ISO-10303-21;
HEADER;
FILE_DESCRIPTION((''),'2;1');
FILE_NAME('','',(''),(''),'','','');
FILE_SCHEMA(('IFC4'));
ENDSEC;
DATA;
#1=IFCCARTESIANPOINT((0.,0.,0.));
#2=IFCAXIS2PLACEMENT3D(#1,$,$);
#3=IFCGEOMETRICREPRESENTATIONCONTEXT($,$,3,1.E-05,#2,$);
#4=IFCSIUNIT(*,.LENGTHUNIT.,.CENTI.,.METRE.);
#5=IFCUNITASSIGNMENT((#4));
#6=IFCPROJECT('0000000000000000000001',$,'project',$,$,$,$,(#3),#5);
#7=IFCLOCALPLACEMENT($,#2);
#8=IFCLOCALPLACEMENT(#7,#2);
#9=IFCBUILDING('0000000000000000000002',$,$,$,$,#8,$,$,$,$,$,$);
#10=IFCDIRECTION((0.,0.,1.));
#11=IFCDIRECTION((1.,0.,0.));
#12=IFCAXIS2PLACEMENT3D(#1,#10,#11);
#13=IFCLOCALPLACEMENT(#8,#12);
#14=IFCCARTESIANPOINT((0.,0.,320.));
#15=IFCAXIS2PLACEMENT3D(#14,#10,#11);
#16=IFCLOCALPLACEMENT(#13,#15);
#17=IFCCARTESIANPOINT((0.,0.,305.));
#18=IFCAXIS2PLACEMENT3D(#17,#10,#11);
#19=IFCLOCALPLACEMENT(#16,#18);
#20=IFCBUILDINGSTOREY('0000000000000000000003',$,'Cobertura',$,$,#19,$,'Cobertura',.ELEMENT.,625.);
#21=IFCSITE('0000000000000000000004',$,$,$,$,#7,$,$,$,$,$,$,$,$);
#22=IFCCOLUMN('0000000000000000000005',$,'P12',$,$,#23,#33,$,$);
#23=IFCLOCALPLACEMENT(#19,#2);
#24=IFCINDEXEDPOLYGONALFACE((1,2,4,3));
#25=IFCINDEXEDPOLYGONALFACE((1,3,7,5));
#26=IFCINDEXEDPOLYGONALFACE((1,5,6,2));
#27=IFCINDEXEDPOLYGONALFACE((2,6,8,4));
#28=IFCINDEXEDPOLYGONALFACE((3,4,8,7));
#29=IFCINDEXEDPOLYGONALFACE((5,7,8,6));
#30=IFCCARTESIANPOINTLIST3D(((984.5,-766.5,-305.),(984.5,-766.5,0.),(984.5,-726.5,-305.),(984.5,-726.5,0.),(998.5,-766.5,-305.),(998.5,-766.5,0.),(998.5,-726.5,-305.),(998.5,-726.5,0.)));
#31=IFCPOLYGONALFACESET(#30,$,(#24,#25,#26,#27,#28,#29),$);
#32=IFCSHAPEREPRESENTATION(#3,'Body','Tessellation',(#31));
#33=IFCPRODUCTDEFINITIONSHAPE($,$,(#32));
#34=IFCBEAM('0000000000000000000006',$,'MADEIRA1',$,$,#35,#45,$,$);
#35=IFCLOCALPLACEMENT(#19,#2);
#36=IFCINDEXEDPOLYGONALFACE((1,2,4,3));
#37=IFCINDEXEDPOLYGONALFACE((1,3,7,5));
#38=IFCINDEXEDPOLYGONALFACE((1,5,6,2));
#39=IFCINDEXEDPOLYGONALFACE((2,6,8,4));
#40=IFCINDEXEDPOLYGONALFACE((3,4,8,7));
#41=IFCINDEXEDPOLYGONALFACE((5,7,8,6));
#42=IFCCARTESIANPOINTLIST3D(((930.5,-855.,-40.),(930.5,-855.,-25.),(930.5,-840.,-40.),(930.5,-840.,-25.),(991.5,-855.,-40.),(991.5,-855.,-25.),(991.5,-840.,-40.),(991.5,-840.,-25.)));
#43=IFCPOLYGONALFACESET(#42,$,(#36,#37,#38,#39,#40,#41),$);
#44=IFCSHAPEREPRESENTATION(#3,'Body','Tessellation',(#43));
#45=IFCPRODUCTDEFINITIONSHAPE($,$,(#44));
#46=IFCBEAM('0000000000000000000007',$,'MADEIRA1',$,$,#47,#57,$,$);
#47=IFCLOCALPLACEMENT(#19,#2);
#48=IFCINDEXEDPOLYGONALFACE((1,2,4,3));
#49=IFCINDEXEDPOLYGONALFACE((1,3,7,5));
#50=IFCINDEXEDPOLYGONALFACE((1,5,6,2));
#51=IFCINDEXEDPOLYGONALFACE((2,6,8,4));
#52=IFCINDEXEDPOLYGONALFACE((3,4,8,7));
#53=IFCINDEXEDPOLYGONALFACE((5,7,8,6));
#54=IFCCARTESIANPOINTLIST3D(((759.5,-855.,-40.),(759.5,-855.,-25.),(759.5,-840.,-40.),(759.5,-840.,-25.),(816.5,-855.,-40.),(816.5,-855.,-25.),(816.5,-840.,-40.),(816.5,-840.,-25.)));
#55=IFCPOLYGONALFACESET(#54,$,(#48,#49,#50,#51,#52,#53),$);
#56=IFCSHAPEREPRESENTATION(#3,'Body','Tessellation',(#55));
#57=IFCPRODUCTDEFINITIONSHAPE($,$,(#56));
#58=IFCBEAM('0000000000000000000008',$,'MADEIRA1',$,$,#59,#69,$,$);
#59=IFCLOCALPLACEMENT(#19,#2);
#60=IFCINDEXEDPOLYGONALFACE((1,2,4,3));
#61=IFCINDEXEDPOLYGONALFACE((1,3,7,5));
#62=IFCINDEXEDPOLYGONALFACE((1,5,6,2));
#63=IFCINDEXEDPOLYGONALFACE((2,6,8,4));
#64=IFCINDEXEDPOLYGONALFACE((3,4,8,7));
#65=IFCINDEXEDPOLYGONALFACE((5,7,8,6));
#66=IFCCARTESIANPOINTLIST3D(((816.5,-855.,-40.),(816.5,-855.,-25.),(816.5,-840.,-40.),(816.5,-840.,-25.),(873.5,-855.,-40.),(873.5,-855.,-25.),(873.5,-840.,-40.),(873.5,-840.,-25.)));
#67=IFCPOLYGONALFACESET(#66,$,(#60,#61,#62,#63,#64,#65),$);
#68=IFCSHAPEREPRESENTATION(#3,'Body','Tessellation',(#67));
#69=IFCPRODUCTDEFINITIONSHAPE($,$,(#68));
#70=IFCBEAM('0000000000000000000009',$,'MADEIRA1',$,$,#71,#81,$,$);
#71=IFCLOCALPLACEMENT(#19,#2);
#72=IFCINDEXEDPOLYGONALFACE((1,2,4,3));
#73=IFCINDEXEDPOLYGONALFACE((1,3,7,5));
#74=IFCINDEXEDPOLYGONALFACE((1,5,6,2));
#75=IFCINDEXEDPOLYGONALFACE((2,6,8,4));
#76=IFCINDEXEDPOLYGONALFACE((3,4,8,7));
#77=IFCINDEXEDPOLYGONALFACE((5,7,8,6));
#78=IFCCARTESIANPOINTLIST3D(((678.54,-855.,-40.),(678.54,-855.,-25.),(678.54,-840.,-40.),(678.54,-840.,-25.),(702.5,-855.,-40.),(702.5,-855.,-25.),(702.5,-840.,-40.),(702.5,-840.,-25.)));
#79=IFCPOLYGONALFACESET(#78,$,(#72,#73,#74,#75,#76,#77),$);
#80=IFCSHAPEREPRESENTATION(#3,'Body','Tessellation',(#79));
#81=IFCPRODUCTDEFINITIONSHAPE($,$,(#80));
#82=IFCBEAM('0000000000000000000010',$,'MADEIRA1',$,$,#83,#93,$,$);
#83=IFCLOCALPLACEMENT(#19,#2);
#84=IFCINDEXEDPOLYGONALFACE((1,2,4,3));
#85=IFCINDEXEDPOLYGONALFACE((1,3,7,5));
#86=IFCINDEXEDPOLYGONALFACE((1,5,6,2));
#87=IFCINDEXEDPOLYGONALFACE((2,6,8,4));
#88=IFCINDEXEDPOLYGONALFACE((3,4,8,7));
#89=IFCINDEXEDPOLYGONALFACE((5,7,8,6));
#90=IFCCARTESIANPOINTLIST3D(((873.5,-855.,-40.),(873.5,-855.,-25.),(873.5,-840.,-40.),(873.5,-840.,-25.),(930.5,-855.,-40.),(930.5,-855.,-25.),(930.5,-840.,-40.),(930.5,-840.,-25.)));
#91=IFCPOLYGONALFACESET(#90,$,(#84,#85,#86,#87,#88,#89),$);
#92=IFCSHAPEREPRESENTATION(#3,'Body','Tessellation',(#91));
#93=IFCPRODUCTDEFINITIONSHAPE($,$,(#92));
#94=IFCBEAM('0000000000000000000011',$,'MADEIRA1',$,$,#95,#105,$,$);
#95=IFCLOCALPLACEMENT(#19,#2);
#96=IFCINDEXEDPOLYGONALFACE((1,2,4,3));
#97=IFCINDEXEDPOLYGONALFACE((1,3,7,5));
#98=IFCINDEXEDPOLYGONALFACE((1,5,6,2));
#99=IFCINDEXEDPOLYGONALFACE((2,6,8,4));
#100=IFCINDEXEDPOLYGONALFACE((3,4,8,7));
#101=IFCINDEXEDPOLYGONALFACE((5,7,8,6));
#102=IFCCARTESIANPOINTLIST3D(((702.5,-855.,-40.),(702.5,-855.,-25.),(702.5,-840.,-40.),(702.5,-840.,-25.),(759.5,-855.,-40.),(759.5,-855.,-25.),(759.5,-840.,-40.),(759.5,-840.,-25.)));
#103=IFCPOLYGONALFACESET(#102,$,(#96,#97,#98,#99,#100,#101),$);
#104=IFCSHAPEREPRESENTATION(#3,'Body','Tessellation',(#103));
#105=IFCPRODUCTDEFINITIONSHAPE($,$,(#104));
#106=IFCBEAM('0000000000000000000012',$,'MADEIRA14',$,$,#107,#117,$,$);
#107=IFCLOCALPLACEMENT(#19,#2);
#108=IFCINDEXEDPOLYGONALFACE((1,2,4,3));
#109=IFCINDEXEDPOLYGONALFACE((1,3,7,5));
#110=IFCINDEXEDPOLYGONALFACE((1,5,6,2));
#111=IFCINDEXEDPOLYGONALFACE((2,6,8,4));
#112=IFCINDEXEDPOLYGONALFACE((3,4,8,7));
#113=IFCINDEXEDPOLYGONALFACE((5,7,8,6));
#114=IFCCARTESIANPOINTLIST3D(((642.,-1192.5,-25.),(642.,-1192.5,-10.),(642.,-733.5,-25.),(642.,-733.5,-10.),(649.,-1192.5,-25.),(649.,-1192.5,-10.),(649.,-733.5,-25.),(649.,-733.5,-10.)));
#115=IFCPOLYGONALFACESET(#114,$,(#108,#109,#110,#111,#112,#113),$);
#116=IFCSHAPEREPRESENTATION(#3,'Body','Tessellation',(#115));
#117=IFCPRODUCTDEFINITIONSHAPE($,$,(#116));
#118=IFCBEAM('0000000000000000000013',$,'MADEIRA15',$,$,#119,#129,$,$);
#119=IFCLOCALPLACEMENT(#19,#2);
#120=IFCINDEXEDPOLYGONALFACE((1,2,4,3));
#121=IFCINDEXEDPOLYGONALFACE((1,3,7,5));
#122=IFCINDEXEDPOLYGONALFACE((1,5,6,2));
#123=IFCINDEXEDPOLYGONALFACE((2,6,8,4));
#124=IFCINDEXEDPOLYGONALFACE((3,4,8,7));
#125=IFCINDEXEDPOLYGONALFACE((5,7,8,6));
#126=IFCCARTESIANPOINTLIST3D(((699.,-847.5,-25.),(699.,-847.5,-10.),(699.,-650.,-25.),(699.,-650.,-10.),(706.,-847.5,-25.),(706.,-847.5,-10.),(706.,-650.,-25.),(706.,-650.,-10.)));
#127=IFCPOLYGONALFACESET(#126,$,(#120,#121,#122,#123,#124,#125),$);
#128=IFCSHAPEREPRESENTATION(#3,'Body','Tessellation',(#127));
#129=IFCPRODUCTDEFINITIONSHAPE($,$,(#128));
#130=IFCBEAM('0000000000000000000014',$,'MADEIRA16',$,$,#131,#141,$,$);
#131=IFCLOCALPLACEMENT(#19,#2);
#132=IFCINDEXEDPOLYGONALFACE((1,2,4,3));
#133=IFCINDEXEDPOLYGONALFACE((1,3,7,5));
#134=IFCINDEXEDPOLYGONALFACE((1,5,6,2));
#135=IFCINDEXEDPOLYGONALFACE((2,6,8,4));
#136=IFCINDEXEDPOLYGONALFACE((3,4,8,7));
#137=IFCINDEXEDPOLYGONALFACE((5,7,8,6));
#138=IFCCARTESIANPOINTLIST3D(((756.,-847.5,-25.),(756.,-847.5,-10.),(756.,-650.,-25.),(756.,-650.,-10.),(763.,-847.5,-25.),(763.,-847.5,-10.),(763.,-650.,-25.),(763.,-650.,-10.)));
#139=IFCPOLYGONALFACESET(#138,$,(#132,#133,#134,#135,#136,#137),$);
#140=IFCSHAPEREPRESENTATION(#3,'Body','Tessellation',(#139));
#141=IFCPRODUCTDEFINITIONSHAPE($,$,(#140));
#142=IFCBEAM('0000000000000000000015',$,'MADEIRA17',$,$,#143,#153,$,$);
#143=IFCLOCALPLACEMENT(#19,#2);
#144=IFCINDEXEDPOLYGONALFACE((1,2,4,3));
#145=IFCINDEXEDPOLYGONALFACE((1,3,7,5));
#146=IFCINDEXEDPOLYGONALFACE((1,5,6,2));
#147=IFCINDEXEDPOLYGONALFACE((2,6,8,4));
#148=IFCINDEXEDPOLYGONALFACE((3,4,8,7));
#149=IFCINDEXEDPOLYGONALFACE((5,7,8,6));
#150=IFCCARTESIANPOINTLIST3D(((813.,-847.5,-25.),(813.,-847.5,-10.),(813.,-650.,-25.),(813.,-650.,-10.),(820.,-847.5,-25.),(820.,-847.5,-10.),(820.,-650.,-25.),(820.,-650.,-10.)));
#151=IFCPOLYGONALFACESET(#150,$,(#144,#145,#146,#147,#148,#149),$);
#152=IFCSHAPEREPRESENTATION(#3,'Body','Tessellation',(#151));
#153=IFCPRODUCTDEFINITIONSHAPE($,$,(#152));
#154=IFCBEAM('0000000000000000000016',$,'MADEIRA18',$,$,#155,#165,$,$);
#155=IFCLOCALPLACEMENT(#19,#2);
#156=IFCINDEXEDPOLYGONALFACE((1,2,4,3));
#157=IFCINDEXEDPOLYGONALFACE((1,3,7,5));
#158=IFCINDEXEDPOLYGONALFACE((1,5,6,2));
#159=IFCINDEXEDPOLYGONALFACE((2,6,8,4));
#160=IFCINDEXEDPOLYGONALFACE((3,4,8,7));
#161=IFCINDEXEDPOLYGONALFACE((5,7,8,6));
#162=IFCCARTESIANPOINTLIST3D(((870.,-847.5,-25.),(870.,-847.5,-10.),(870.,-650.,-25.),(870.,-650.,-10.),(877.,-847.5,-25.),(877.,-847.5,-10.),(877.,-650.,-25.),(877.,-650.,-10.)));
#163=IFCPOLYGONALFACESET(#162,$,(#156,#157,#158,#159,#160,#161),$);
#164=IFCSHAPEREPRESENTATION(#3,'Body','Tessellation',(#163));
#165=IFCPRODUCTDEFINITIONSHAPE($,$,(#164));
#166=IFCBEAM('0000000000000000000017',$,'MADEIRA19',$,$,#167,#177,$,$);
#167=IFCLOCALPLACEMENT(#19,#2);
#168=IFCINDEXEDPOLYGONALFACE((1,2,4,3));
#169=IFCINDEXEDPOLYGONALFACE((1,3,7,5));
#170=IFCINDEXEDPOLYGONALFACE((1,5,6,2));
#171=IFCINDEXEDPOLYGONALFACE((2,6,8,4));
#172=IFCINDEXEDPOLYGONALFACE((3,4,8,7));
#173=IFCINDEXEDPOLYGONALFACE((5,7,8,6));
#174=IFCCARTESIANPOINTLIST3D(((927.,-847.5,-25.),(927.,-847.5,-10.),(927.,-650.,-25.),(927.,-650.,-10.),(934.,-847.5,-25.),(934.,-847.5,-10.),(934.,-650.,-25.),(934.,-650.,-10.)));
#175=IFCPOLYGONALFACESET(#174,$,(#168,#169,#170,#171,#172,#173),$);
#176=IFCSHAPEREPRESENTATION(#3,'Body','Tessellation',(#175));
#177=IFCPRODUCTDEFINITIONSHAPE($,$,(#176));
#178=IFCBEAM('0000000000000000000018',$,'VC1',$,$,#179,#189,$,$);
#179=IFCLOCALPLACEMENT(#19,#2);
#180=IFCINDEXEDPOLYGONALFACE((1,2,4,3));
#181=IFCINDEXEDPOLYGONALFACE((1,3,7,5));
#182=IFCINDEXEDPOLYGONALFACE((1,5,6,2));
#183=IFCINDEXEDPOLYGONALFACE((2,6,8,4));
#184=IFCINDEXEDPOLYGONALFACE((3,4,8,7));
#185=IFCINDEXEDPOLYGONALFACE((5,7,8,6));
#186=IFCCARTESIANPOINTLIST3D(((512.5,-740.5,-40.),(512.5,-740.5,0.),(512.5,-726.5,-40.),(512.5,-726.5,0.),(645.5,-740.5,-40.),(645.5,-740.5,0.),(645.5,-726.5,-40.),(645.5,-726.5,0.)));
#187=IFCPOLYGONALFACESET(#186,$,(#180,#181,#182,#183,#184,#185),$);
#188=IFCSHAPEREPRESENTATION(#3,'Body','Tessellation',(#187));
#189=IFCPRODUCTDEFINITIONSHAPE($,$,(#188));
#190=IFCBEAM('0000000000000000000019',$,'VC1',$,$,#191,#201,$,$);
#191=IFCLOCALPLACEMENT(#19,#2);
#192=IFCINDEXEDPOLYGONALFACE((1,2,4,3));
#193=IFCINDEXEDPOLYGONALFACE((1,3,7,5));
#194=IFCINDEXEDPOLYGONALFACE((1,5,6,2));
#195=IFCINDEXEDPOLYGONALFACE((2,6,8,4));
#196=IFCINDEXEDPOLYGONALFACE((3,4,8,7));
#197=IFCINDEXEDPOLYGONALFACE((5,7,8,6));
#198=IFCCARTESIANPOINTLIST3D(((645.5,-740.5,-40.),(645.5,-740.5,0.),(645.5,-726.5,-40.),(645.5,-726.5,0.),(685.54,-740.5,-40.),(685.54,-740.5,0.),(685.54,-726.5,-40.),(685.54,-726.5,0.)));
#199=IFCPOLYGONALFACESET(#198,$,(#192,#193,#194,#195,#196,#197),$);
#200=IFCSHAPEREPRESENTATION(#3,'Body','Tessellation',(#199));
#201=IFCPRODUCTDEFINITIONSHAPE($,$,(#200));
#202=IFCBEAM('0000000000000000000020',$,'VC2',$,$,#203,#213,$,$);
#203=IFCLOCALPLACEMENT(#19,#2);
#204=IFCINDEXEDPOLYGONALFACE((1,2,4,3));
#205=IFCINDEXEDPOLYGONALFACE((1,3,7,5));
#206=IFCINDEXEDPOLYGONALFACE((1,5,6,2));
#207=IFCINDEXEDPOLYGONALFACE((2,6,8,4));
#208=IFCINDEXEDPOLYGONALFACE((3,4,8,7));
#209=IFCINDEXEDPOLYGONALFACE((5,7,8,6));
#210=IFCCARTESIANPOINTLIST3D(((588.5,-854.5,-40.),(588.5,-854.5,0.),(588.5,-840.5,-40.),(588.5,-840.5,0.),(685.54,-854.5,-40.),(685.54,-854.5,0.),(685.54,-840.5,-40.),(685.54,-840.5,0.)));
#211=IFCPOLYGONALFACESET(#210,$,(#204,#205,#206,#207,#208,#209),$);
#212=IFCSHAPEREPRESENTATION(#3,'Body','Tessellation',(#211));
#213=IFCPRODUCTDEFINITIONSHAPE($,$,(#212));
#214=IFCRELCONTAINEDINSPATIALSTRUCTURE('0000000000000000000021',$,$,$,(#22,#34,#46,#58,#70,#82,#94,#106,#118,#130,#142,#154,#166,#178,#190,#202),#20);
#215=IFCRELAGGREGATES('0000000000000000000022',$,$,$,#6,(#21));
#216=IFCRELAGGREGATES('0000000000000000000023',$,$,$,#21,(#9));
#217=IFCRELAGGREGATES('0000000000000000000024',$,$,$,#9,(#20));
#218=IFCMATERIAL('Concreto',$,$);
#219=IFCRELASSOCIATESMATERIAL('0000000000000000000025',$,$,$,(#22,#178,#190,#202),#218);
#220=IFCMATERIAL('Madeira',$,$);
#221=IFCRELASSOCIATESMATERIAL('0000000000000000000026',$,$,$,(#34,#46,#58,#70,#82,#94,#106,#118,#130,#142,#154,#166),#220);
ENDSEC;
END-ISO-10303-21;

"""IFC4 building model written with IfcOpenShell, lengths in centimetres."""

from ifc_helpers import new_model, si_unit, frame, origin, origin_with_axes, place, context, project, spatial, polyline, outline, extrude, material, element, save


model = new_model("IFC4")

# Units and contexts
context_of_model = context(None, 3, precision=1e-05, world=origin())
ifc_project = project(units=[si_unit("LENGTHUNIT", "METRE", prefix="CENTI")], contexts=[context_of_model])

# Site, building, storey
site_placement = place(None, origin())
site = spatial("IfcSite", under=ifc_project, at=site_placement)
building_placement = place(site_placement, origin())
building = spatial("IfcBuilding", under=site, at=building_placement)
placement_1 = place(building_placement, origin_with_axes())
placement_2 = place(placement_1, frame((0.0, 0.0, 320.0), z_axis=(0.0, 0.0, 1.0), x_axis=(1.0, 0.0, 0.0)))
storey_placement = place(placement_2, frame((0.0, 0.0, 305.0), z_axis=(0.0, 0.0, 1.0), x_axis=(1.0, 0.0, 0.0)))
storey = spatial("IfcBuildingStorey", under=building, at=storey_placement, Name="Cobertura", LongName="Cobertura", CompositionType="ELEMENT", Elevation=625.0)

# Column
ifc_material_1 = material(Name="Concreto")
column_placement = place(storey_placement, frame((991.5, -746.5, 0.0), z_axis=(0.0, 0.0, 1.0), x_axis=(1.0, 0.0, 0.0)))
element("IfcColumn", 1, at=column_placement, inside=storey, material=ifc_material_1, Name="P12", context=context_of_model, shape_type="SolidModel", body=[
    extrude(outline(polyline([(-7.0, -20.0), (7.0, -20.0), (7.0, 20.0), (-7.0, 20.0), (-7.0, -20.0)])), origin_with_axes(), (0.0, 0.0, -1.0), 305.0),
])

# Beams
ifc_material_2 = material(Name="Madeira")
beam_1_placement = place(storey_placement, frame((961.0, -847.5, -25.0), z_axis=(0.0, 0.0, 1.0), x_axis=(1.0, 0.0, 0.0)))
element("IfcBeam", 2, at=beam_1_placement, inside=storey, material=ifc_material_2, Name="MADEIRA1", context=context_of_model, shape_type="SolidModel", body=[
    extrude(outline(polyline([(-7.5, -7.5), (-7.5, 7.5), (7.5, 7.5), (7.5, -7.5), (-7.5, -7.5)])), frame((-30.5, 0.0, -7.5), z_axis=(1.0, 0.0, 0.0), x_axis=(0.0, -1.0, 0.0)), (0.0, 0.0, 1.0), 61.0),
])
for number, where, z_axis, x_axis, name in (
    (3, (788.0, -847.5, -25.0), (0.0, 0.0, 1.0), (1.0, 0.0, 0.0), "MADEIRA1"),
    (4, (845.0, -847.5, -25.0), (0.0, 0.0, 1.0), (1.0, 0.0, 0.0), "MADEIRA1"),
):
    element("IfcBeam", number, at=place(storey_placement, frame(where, z_axis=z_axis, x_axis=x_axis)), inside=storey, material=ifc_material_2, Name=name, context=context_of_model, shape_type="SolidModel", body=[
        extrude(outline(polyline([(-7.5, -7.5), (-7.5, 7.5), (7.5, 7.5), (7.5, -7.5), (-7.5, -7.5)])), frame((-28.5, 0.0, -7.5), z_axis=(1.0, 0.0, 0.0), x_axis=(0.0, -1.0, 0.0)), (0.0, 0.0, 1.0), 57.0),
    ])
beam_2_placement = place(storey_placement, frame((690.52, -847.5, -25.0), z_axis=(0.0, 0.0, 1.0), x_axis=(1.0, 0.0, 0.0)))
element("IfcBeam", 5, at=beam_2_placement, inside=storey, material=ifc_material_2, Name="MADEIRA1", context=context_of_model, shape_type="SolidModel", body=[
    extrude(outline(polyline([(-7.5, -7.5), (-7.5, 7.5), (7.5, 7.5), (7.5, -7.5), (-7.5, -7.5)])), frame((-11.98, 0.0, -7.5), z_axis=(1.0, 0.0, 0.0), x_axis=(0.0, -1.0, 0.0)), (0.0, 0.0, 1.0), 23.96),
])
for number, where, z_axis, x_axis, name in (
    (6, (902.0, -847.5, -25.0), (0.0, 0.0, 1.0), (1.0, 0.0, 0.0), "MADEIRA1"),
    (7, (731.0, -847.5, -25.0), (0.0, 0.0, 1.0), (1.0, 0.0, 0.0), "MADEIRA1"),
):
    element("IfcBeam", number, at=place(storey_placement, frame(where, z_axis=z_axis, x_axis=x_axis)), inside=storey, material=ifc_material_2, Name=name, context=context_of_model, shape_type="SolidModel", body=[
        extrude(outline(polyline([(-7.5, -7.5), (-7.5, 7.5), (7.5, 7.5), (7.5, -7.5), (-7.5, -7.5)])), frame((-28.5, 0.0, -7.5), z_axis=(1.0, 0.0, 0.0), x_axis=(0.0, -1.0, 0.0)), (0.0, 0.0, 1.0), 57.0),
    ])
beam_3_placement = place(storey_placement, frame((645.5, -963.0, -10.0), z_axis=(0.0, 0.0, 1.0), x_axis=(1.0, 0.0, 0.0)))
element("IfcBeam", 8, at=beam_3_placement, inside=storey, material=ifc_material_2, Name="MADEIRA14", context=context_of_model, shape_type="SolidModel", body=[
    extrude(outline(polyline([(-3.5, -7.5), (-3.5, 7.5), (3.5, 7.5), (3.5, -7.5), (-3.5, -7.5)])), frame((0.0, -229.5, -7.5), z_axis=(0.0, 1.0, 0.0), x_axis=(1.0, 0.0, 0.0)), (0.0, 0.0, 1.0), 459.0),
])
for number, where, z_axis, x_axis, name in (
    (9, (702.5, -748.75, -10.0), (0.0, 0.0, 1.0), (1.0, 0.0, 0.0), "MADEIRA15"),
    (10, (759.5, -748.75, -10.0), (0.0, 0.0, 1.0), (1.0, 0.0, 0.0), "MADEIRA16"),
    (11, (816.5, -748.75, -10.0), (0.0, 0.0, 1.0), (1.0, 0.0, 0.0), "MADEIRA17"),
    (12, (873.5, -748.75, -10.0), (0.0, 0.0, 1.0), (1.0, 0.0, 0.0), "MADEIRA18"),
    (13, (930.5, -748.75, -10.0), (0.0, 0.0, 1.0), (1.0, 0.0, 0.0), "MADEIRA19"),
):
    element("IfcBeam", number, at=place(storey_placement, frame(where, z_axis=z_axis, x_axis=x_axis)), inside=storey, material=ifc_material_2, Name=name, context=context_of_model, shape_type="SolidModel", body=[
        extrude(outline(polyline([(-3.5, -7.5), (-3.5, 7.5), (3.5, 7.5), (3.5, -7.5), (-3.5, -7.5)])), frame((0.0, -98.75, -7.5), z_axis=(0.0, 1.0, 0.0), x_axis=(1.0, 0.0, 0.0)), (0.0, 0.0, 1.0), 197.5),
    ])
beam_4_placement = place(storey_placement, frame((579.0, -733.5, 0.0), z_axis=(0.0, 0.0, 1.0), x_axis=(1.0, 0.0, 0.0)))
element("IfcBeam", 14, at=beam_4_placement, inside=storey, material=ifc_material_1, Name="VC1", context=context_of_model, shape_type="SolidModel", body=[
    extrude(outline(polyline([(-7.0, -20.0), (7.0, -20.0), (7.0, 20.0), (-7.0, 20.0), (-7.0, -20.0)])), frame((-66.5, 0.0, -20.0), z_axis=(1.0, 0.0, 0.0), x_axis=(0.0, -1.0, 0.0)), (0.0, 0.0, 1.0), 133.0),
])
beam_5_placement = place(storey_placement, frame((665.52, -733.5, 0.0), z_axis=(0.0, 0.0, 1.0), x_axis=(1.0, 0.0, 0.0)))
element("IfcBeam", 15, at=beam_5_placement, inside=storey, material=ifc_material_1, Name="VC1", context=context_of_model, shape_type="SolidModel", body=[
    extrude(outline(polyline([(-7.0, -20.0), (7.0, -20.0), (7.0, 20.0), (-7.0, 20.0), (-7.0, -20.0)])), frame((-20.02, 0.0, -20.0), z_axis=(1.0, 0.0, 0.0), x_axis=(0.0, -1.0, 0.0)), (0.0, 0.0, 1.0), 40.04),
])
beam_6_placement = place(storey_placement, frame((637.02, -847.5, 0.0), z_axis=(0.0, 0.0, 1.0), x_axis=(1.0, 0.0, 0.0)))
element("IfcBeam", 16, at=beam_6_placement, inside=storey, material=ifc_material_1, Name="VC2", context=context_of_model, shape_type="SolidModel", body=[
    extrude(outline(polyline([(-7.0, -20.0), (7.0, -20.0), (7.0, 20.0), (-7.0, 20.0), (-7.0, -20.0)])), frame((-48.52, 0.0, -20.0), z_axis=(1.0, 0.0, 0.0), x_axis=(0.0, -1.0, 0.0)), (0.0, 0.0, 1.0), 97.04),
])

save(model, "model.ifc")
